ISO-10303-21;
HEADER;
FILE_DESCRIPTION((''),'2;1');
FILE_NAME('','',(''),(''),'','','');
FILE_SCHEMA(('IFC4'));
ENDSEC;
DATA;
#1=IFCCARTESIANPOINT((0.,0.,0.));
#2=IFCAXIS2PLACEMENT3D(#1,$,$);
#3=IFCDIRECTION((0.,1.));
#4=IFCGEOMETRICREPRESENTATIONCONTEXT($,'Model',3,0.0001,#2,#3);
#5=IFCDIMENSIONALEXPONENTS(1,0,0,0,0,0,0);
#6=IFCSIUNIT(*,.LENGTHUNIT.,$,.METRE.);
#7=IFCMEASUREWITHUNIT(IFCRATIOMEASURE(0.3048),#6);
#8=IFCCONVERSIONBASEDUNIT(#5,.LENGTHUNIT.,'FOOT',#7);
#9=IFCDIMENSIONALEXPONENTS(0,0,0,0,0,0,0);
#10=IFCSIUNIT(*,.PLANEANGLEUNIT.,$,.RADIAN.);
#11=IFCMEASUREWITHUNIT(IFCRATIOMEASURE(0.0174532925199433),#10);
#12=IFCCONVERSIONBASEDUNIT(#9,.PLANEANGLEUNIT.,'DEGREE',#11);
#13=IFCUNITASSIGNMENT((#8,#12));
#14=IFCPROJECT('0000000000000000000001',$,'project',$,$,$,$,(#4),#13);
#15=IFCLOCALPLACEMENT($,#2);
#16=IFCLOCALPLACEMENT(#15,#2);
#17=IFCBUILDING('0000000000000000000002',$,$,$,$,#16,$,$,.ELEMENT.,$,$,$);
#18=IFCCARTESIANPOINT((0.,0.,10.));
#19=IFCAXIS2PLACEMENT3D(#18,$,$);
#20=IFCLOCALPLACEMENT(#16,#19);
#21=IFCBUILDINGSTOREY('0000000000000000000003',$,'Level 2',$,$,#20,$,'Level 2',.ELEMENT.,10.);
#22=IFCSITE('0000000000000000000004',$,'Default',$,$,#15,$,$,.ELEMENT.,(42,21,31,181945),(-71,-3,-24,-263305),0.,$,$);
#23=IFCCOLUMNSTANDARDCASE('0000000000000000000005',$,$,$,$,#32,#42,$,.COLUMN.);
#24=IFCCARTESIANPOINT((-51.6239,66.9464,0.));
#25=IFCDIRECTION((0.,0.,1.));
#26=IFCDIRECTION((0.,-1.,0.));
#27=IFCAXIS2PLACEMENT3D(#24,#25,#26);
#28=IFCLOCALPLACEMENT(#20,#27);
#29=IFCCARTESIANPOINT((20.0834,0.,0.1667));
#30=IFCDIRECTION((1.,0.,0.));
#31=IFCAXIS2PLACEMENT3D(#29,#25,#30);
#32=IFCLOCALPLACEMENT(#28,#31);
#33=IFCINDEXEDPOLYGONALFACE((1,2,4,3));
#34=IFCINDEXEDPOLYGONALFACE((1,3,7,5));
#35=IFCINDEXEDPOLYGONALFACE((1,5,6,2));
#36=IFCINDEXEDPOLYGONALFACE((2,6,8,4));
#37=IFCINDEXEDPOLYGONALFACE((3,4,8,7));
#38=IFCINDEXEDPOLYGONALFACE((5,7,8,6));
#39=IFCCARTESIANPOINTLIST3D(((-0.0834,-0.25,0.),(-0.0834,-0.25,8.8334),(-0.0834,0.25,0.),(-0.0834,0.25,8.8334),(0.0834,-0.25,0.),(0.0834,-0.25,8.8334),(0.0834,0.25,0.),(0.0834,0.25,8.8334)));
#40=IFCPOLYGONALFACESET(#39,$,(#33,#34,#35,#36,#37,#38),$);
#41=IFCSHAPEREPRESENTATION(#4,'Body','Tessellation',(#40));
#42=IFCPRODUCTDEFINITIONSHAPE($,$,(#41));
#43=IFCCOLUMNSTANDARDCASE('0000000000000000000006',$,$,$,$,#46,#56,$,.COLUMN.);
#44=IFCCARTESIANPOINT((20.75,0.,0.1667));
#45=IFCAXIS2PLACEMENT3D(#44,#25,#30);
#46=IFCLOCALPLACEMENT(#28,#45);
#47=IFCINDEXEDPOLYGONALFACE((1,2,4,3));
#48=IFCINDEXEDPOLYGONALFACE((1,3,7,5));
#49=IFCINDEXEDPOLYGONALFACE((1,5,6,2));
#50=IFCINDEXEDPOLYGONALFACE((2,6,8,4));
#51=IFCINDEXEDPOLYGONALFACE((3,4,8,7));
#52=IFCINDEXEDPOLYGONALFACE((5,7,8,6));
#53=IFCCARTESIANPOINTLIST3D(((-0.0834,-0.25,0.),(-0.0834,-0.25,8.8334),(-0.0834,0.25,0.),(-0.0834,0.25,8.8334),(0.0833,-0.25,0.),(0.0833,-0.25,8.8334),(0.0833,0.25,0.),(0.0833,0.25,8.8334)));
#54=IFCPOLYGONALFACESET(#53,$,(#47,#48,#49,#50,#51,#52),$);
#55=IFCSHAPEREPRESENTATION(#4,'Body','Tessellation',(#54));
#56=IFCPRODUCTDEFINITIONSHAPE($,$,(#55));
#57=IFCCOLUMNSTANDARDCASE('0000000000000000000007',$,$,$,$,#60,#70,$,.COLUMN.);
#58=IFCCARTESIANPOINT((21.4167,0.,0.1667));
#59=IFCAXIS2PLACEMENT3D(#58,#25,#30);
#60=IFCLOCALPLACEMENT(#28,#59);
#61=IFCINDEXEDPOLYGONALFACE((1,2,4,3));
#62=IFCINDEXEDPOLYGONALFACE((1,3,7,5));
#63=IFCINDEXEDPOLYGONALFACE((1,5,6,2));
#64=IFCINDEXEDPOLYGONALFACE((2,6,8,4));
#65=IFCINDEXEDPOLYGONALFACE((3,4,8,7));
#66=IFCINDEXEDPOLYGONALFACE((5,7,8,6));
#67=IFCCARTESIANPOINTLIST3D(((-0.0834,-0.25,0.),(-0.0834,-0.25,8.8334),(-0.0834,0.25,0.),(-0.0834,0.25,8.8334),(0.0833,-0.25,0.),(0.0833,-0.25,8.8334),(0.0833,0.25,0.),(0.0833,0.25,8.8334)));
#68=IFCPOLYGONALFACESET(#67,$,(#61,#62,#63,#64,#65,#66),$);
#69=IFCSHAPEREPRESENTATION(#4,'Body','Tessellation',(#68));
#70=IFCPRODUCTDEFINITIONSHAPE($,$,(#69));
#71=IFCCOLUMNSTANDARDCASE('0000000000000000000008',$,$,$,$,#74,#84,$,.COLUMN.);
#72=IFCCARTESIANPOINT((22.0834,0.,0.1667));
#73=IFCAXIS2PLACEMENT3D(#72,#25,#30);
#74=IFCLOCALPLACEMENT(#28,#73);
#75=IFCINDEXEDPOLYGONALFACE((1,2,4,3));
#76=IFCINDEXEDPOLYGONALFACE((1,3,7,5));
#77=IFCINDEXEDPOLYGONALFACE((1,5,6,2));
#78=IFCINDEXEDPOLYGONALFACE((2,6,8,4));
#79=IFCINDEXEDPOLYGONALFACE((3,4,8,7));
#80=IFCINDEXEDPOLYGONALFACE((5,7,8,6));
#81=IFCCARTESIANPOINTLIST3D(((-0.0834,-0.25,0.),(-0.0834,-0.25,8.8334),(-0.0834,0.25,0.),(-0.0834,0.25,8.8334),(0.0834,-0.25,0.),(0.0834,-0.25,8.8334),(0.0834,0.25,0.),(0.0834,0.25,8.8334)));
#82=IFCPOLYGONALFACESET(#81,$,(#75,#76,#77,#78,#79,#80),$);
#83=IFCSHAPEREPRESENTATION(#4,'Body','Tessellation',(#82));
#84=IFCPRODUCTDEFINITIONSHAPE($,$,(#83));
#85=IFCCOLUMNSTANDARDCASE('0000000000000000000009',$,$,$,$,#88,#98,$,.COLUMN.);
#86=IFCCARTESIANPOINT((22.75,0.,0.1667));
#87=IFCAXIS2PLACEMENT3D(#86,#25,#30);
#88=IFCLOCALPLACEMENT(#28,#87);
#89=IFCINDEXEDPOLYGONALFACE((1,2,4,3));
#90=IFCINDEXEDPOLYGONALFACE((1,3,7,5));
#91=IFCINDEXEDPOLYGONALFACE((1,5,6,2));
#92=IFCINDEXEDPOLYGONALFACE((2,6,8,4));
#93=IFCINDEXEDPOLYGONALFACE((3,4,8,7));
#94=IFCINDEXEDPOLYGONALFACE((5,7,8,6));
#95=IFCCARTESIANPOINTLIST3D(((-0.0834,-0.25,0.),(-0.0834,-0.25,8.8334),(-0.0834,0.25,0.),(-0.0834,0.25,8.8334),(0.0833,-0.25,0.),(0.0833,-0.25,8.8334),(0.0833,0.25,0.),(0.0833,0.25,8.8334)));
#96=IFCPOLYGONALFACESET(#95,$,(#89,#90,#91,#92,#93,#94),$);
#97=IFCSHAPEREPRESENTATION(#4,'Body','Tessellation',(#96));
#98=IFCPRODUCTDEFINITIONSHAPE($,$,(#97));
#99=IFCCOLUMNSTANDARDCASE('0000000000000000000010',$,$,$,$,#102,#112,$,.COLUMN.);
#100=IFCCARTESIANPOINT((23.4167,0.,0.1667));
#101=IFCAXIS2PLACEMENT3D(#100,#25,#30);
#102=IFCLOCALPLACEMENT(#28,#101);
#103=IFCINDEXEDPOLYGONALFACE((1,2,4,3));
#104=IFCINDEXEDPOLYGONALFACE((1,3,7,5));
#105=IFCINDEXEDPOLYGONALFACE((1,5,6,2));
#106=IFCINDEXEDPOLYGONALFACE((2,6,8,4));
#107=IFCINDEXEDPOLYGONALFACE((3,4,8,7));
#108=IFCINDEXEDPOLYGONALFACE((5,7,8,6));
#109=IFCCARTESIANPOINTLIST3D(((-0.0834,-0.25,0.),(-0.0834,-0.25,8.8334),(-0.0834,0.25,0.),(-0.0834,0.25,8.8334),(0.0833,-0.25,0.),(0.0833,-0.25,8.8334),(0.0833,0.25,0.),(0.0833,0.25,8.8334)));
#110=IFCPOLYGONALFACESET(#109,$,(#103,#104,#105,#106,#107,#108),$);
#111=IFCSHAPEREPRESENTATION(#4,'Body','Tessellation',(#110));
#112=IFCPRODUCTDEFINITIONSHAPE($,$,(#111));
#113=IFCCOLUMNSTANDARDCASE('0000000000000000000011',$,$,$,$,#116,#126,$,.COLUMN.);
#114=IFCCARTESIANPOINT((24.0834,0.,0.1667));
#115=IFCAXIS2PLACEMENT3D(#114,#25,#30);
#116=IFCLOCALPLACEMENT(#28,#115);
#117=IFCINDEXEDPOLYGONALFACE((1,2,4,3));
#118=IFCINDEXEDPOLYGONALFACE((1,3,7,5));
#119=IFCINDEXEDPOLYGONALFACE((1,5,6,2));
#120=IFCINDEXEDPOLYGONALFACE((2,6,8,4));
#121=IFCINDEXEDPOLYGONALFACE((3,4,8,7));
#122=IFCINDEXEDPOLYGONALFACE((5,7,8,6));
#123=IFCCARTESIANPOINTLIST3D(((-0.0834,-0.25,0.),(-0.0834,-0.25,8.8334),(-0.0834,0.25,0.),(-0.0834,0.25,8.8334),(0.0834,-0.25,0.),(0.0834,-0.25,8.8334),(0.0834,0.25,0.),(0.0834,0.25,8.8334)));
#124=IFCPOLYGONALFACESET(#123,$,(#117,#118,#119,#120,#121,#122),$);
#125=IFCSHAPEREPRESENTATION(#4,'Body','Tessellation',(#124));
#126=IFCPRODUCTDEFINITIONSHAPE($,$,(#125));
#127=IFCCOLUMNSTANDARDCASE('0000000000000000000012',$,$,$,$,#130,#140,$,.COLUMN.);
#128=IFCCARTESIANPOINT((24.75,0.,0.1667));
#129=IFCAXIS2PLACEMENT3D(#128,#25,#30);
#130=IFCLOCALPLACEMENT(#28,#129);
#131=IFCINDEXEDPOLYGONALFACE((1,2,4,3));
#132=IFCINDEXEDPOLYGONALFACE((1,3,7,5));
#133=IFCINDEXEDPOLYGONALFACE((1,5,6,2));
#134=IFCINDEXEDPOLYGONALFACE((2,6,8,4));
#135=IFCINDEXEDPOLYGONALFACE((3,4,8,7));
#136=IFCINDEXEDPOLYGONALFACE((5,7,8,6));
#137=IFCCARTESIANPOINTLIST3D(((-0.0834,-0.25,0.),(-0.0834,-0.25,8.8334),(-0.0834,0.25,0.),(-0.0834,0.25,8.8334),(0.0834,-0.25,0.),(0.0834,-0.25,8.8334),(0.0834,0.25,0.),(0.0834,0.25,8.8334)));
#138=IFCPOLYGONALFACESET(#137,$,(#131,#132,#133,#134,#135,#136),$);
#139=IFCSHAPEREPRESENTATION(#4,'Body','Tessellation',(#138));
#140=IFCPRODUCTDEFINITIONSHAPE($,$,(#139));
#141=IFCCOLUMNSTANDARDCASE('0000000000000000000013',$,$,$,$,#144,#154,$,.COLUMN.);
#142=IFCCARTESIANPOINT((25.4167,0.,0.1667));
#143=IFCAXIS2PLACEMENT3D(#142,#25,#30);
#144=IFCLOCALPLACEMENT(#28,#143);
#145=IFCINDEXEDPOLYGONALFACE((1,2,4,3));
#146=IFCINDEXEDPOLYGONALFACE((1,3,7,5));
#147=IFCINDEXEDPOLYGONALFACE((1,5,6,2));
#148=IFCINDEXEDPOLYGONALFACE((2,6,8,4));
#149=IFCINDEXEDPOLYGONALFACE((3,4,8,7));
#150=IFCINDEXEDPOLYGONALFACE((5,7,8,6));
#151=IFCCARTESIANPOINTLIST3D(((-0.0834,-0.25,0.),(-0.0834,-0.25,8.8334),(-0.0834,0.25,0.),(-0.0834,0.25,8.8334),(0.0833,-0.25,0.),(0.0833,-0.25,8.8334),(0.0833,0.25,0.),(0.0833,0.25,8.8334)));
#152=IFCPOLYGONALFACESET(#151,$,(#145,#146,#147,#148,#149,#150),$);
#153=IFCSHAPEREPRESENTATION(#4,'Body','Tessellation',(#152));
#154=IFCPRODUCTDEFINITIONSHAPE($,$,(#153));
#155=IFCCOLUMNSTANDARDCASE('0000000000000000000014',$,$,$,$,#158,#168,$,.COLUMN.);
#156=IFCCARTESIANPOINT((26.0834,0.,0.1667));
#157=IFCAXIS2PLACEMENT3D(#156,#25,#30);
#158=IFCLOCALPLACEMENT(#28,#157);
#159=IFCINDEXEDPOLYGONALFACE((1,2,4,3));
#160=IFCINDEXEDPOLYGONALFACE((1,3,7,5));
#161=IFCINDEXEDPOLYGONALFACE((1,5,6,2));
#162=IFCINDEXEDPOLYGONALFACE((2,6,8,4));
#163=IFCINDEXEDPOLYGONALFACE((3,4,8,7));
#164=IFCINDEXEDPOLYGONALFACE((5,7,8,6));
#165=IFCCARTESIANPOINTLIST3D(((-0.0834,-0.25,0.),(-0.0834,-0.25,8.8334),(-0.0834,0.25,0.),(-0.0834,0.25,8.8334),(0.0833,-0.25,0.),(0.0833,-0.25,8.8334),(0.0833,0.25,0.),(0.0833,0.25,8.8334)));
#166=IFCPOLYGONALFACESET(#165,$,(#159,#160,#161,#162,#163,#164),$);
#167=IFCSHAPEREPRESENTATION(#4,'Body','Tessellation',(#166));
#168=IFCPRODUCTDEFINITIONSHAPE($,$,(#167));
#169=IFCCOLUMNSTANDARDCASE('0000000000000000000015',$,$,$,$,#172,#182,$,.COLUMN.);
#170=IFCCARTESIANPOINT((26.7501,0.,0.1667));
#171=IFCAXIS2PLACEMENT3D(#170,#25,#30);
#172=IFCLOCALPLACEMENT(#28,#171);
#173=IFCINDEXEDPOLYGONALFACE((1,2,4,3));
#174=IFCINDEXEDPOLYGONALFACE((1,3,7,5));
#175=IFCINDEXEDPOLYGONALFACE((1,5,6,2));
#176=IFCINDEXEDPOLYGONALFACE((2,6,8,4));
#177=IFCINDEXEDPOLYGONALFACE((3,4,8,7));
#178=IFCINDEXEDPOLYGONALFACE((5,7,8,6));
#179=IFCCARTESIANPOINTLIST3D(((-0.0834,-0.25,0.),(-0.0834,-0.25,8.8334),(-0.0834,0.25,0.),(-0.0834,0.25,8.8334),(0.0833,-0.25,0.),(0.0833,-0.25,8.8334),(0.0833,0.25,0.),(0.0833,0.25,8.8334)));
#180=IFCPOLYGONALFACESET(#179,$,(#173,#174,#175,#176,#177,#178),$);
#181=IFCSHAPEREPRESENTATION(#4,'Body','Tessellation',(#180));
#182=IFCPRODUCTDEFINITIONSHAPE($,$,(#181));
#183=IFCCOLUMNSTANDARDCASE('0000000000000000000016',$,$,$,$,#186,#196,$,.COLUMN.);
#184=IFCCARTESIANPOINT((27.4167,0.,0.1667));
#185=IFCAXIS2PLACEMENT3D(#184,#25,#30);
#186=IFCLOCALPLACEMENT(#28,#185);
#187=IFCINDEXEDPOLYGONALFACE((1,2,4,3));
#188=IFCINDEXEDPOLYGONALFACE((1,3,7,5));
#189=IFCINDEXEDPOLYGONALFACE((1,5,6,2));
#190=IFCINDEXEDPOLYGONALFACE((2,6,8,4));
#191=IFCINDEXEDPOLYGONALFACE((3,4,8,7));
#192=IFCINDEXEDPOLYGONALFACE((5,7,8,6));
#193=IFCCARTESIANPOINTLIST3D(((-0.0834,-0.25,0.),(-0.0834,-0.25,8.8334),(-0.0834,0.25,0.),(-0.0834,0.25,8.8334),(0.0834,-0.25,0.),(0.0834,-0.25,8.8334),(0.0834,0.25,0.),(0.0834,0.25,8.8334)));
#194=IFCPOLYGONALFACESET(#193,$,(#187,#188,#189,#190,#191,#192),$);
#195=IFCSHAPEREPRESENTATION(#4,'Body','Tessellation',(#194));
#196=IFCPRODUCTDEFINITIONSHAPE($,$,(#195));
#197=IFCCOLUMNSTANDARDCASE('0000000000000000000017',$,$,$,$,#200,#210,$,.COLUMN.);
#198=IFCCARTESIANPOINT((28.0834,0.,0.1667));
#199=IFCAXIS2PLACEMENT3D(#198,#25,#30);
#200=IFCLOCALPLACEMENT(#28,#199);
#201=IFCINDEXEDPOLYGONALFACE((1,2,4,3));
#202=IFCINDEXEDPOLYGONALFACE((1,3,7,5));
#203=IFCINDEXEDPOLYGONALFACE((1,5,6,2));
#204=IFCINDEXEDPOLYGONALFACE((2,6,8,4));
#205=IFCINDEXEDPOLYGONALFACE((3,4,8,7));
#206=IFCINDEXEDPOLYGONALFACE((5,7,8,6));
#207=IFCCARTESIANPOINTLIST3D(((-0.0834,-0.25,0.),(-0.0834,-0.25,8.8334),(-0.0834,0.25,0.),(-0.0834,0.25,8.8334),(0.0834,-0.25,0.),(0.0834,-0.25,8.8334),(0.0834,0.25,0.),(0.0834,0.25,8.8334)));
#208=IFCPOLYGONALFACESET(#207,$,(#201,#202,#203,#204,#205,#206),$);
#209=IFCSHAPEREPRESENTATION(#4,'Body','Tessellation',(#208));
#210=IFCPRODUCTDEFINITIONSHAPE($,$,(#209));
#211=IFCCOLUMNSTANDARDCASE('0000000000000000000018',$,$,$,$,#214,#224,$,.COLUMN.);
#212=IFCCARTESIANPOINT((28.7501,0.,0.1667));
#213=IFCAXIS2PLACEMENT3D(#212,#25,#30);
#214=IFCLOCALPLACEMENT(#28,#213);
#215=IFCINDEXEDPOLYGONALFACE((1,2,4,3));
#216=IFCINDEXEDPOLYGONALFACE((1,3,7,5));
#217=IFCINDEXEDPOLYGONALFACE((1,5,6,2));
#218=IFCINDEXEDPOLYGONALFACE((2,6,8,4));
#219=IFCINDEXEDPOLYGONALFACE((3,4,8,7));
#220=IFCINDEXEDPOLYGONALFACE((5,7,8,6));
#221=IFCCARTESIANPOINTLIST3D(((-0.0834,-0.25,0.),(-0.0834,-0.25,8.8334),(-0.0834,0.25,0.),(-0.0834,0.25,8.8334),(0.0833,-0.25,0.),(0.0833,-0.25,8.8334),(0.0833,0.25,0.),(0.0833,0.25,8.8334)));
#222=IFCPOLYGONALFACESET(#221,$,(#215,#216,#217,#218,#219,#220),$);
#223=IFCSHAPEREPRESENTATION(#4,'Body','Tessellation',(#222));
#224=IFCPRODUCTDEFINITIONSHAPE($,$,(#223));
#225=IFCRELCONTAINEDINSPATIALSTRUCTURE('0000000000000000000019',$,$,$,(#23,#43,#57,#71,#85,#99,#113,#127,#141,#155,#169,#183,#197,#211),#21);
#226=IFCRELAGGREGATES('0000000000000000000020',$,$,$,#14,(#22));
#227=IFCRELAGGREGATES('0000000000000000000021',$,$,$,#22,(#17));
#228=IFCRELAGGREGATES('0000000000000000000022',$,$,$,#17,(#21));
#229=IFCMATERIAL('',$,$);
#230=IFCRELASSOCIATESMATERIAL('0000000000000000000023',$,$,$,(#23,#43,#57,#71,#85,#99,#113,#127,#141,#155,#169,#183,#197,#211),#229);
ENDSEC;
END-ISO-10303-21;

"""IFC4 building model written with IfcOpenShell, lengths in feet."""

from ifc_helpers import new_model, entity, si_unit, converted_unit, direction, frame, origin, place, context, project, spatial, rectangle, extrude, material, element, save


model = new_model("IFC4")

# Units and contexts
model_context = context("Model", 3, precision=0.0001, world=origin(), true_north=direction((0.0, 1.0)))
ifc_project = project(units=[converted_unit("LENGTHUNIT", "FOOT", entity("IfcRatioMeasure", 0.3048), si_unit("LENGTHUNIT", "METRE"), dimensions=[1, 0, 0, 0, 0, 0, 0]), converted_unit("PLANEANGLEUNIT", "DEGREE", entity("IfcRatioMeasure", 0.0174532925199433), si_unit("PLANEANGLEUNIT", "RADIAN"), dimensions=[0, 0, 0, 0, 0, 0, 0])], contexts=[model_context])

# Site, building, storey
site_placement = place(None, origin())
site = spatial("IfcSite", under=ifc_project, at=site_placement, Name="Default", CompositionType="ELEMENT", RefLatitude=(42, 21, 31, 181945), RefLongitude=(-71, -3, -24, -263305), RefElevation=0.0)
building_placement = place(site_placement, origin())
building = spatial("IfcBuilding", under=site, at=building_placement, CompositionType="ELEMENT")
storey_placement = place(building_placement, frame((0.0, 0.0, 10.0)))
storey = spatial("IfcBuildingStorey", under=building, at=storey_placement, Name="Level 2", LongName="Level 2", CompositionType="ELEMENT", Elevation=10.0)

# Columns
ifc_material_1 = material(Name="")
placement_1 = place(storey_placement, frame((-51.6239, 66.9464, 0.0), z_axis=(0.0, 0.0, 1.0), x_axis=(0.0, -1.0, 0.0)))
for number, where, z_axis, x_axis in (
    (1, (20.0834, 0.0, 0.1667), (0.0, 0.0, 1.0), (1.0, 0.0, 0.0)),
    (2, (20.75, 0.0, 0.1667), (0.0, 0.0, 1.0), (1.0, 0.0, 0.0)),
    (3, (21.4167, 0.0, 0.1667), (0.0, 0.0, 1.0), (1.0, 0.0, 0.0)),
    (4, (22.0834, 0.0, 0.1667), (0.0, 0.0, 1.0), (1.0, 0.0, 0.0)),
    (5, (22.75, 0.0, 0.1667), (0.0, 0.0, 1.0), (1.0, 0.0, 0.0)),
    (6, (23.4167, 0.0, 0.1667), (0.0, 0.0, 1.0), (1.0, 0.0, 0.0)),
    (7, (24.0834, 0.0, 0.1667), (0.0, 0.0, 1.0), (1.0, 0.0, 0.0)),
    (8, (24.75, 0.0, 0.1667), (0.0, 0.0, 1.0), (1.0, 0.0, 0.0)),
    (9, (25.4167, 0.0, 0.1667), (0.0, 0.0, 1.0), (1.0, 0.0, 0.0)),
    (10, (26.0834, 0.0, 0.1667), (0.0, 0.0, 1.0), (1.0, 0.0, 0.0)),
    (11, (26.7501, 0.0, 0.1667), (0.0, 0.0, 1.0), (1.0, 0.0, 0.0)),
    (12, (27.4167, 0.0, 0.1667), (0.0, 0.0, 1.0), (1.0, 0.0, 0.0)),
    (13, (28.0834, 0.0, 0.1667), (0.0, 0.0, 1.0), (1.0, 0.0, 0.0)),
    (14, (28.7501, 0.0, 0.1667), (0.0, 0.0, 1.0), (1.0, 0.0, 0.0)),
):
    element("IfcColumnStandardCase", number, at=place(placement_1, frame(where, z_axis=z_axis, x_axis=x_axis)), inside=storey, material=ifc_material_1, PredefinedType="COLUMN", context=model_context, shape_type="SweptSolid", body=[
        extrude(rectangle(XDim=0.1667, YDim=0.5), origin(), (0.0, 0.0, 1.0), 8.8334),
    ])

save(model, "model.ifc")
